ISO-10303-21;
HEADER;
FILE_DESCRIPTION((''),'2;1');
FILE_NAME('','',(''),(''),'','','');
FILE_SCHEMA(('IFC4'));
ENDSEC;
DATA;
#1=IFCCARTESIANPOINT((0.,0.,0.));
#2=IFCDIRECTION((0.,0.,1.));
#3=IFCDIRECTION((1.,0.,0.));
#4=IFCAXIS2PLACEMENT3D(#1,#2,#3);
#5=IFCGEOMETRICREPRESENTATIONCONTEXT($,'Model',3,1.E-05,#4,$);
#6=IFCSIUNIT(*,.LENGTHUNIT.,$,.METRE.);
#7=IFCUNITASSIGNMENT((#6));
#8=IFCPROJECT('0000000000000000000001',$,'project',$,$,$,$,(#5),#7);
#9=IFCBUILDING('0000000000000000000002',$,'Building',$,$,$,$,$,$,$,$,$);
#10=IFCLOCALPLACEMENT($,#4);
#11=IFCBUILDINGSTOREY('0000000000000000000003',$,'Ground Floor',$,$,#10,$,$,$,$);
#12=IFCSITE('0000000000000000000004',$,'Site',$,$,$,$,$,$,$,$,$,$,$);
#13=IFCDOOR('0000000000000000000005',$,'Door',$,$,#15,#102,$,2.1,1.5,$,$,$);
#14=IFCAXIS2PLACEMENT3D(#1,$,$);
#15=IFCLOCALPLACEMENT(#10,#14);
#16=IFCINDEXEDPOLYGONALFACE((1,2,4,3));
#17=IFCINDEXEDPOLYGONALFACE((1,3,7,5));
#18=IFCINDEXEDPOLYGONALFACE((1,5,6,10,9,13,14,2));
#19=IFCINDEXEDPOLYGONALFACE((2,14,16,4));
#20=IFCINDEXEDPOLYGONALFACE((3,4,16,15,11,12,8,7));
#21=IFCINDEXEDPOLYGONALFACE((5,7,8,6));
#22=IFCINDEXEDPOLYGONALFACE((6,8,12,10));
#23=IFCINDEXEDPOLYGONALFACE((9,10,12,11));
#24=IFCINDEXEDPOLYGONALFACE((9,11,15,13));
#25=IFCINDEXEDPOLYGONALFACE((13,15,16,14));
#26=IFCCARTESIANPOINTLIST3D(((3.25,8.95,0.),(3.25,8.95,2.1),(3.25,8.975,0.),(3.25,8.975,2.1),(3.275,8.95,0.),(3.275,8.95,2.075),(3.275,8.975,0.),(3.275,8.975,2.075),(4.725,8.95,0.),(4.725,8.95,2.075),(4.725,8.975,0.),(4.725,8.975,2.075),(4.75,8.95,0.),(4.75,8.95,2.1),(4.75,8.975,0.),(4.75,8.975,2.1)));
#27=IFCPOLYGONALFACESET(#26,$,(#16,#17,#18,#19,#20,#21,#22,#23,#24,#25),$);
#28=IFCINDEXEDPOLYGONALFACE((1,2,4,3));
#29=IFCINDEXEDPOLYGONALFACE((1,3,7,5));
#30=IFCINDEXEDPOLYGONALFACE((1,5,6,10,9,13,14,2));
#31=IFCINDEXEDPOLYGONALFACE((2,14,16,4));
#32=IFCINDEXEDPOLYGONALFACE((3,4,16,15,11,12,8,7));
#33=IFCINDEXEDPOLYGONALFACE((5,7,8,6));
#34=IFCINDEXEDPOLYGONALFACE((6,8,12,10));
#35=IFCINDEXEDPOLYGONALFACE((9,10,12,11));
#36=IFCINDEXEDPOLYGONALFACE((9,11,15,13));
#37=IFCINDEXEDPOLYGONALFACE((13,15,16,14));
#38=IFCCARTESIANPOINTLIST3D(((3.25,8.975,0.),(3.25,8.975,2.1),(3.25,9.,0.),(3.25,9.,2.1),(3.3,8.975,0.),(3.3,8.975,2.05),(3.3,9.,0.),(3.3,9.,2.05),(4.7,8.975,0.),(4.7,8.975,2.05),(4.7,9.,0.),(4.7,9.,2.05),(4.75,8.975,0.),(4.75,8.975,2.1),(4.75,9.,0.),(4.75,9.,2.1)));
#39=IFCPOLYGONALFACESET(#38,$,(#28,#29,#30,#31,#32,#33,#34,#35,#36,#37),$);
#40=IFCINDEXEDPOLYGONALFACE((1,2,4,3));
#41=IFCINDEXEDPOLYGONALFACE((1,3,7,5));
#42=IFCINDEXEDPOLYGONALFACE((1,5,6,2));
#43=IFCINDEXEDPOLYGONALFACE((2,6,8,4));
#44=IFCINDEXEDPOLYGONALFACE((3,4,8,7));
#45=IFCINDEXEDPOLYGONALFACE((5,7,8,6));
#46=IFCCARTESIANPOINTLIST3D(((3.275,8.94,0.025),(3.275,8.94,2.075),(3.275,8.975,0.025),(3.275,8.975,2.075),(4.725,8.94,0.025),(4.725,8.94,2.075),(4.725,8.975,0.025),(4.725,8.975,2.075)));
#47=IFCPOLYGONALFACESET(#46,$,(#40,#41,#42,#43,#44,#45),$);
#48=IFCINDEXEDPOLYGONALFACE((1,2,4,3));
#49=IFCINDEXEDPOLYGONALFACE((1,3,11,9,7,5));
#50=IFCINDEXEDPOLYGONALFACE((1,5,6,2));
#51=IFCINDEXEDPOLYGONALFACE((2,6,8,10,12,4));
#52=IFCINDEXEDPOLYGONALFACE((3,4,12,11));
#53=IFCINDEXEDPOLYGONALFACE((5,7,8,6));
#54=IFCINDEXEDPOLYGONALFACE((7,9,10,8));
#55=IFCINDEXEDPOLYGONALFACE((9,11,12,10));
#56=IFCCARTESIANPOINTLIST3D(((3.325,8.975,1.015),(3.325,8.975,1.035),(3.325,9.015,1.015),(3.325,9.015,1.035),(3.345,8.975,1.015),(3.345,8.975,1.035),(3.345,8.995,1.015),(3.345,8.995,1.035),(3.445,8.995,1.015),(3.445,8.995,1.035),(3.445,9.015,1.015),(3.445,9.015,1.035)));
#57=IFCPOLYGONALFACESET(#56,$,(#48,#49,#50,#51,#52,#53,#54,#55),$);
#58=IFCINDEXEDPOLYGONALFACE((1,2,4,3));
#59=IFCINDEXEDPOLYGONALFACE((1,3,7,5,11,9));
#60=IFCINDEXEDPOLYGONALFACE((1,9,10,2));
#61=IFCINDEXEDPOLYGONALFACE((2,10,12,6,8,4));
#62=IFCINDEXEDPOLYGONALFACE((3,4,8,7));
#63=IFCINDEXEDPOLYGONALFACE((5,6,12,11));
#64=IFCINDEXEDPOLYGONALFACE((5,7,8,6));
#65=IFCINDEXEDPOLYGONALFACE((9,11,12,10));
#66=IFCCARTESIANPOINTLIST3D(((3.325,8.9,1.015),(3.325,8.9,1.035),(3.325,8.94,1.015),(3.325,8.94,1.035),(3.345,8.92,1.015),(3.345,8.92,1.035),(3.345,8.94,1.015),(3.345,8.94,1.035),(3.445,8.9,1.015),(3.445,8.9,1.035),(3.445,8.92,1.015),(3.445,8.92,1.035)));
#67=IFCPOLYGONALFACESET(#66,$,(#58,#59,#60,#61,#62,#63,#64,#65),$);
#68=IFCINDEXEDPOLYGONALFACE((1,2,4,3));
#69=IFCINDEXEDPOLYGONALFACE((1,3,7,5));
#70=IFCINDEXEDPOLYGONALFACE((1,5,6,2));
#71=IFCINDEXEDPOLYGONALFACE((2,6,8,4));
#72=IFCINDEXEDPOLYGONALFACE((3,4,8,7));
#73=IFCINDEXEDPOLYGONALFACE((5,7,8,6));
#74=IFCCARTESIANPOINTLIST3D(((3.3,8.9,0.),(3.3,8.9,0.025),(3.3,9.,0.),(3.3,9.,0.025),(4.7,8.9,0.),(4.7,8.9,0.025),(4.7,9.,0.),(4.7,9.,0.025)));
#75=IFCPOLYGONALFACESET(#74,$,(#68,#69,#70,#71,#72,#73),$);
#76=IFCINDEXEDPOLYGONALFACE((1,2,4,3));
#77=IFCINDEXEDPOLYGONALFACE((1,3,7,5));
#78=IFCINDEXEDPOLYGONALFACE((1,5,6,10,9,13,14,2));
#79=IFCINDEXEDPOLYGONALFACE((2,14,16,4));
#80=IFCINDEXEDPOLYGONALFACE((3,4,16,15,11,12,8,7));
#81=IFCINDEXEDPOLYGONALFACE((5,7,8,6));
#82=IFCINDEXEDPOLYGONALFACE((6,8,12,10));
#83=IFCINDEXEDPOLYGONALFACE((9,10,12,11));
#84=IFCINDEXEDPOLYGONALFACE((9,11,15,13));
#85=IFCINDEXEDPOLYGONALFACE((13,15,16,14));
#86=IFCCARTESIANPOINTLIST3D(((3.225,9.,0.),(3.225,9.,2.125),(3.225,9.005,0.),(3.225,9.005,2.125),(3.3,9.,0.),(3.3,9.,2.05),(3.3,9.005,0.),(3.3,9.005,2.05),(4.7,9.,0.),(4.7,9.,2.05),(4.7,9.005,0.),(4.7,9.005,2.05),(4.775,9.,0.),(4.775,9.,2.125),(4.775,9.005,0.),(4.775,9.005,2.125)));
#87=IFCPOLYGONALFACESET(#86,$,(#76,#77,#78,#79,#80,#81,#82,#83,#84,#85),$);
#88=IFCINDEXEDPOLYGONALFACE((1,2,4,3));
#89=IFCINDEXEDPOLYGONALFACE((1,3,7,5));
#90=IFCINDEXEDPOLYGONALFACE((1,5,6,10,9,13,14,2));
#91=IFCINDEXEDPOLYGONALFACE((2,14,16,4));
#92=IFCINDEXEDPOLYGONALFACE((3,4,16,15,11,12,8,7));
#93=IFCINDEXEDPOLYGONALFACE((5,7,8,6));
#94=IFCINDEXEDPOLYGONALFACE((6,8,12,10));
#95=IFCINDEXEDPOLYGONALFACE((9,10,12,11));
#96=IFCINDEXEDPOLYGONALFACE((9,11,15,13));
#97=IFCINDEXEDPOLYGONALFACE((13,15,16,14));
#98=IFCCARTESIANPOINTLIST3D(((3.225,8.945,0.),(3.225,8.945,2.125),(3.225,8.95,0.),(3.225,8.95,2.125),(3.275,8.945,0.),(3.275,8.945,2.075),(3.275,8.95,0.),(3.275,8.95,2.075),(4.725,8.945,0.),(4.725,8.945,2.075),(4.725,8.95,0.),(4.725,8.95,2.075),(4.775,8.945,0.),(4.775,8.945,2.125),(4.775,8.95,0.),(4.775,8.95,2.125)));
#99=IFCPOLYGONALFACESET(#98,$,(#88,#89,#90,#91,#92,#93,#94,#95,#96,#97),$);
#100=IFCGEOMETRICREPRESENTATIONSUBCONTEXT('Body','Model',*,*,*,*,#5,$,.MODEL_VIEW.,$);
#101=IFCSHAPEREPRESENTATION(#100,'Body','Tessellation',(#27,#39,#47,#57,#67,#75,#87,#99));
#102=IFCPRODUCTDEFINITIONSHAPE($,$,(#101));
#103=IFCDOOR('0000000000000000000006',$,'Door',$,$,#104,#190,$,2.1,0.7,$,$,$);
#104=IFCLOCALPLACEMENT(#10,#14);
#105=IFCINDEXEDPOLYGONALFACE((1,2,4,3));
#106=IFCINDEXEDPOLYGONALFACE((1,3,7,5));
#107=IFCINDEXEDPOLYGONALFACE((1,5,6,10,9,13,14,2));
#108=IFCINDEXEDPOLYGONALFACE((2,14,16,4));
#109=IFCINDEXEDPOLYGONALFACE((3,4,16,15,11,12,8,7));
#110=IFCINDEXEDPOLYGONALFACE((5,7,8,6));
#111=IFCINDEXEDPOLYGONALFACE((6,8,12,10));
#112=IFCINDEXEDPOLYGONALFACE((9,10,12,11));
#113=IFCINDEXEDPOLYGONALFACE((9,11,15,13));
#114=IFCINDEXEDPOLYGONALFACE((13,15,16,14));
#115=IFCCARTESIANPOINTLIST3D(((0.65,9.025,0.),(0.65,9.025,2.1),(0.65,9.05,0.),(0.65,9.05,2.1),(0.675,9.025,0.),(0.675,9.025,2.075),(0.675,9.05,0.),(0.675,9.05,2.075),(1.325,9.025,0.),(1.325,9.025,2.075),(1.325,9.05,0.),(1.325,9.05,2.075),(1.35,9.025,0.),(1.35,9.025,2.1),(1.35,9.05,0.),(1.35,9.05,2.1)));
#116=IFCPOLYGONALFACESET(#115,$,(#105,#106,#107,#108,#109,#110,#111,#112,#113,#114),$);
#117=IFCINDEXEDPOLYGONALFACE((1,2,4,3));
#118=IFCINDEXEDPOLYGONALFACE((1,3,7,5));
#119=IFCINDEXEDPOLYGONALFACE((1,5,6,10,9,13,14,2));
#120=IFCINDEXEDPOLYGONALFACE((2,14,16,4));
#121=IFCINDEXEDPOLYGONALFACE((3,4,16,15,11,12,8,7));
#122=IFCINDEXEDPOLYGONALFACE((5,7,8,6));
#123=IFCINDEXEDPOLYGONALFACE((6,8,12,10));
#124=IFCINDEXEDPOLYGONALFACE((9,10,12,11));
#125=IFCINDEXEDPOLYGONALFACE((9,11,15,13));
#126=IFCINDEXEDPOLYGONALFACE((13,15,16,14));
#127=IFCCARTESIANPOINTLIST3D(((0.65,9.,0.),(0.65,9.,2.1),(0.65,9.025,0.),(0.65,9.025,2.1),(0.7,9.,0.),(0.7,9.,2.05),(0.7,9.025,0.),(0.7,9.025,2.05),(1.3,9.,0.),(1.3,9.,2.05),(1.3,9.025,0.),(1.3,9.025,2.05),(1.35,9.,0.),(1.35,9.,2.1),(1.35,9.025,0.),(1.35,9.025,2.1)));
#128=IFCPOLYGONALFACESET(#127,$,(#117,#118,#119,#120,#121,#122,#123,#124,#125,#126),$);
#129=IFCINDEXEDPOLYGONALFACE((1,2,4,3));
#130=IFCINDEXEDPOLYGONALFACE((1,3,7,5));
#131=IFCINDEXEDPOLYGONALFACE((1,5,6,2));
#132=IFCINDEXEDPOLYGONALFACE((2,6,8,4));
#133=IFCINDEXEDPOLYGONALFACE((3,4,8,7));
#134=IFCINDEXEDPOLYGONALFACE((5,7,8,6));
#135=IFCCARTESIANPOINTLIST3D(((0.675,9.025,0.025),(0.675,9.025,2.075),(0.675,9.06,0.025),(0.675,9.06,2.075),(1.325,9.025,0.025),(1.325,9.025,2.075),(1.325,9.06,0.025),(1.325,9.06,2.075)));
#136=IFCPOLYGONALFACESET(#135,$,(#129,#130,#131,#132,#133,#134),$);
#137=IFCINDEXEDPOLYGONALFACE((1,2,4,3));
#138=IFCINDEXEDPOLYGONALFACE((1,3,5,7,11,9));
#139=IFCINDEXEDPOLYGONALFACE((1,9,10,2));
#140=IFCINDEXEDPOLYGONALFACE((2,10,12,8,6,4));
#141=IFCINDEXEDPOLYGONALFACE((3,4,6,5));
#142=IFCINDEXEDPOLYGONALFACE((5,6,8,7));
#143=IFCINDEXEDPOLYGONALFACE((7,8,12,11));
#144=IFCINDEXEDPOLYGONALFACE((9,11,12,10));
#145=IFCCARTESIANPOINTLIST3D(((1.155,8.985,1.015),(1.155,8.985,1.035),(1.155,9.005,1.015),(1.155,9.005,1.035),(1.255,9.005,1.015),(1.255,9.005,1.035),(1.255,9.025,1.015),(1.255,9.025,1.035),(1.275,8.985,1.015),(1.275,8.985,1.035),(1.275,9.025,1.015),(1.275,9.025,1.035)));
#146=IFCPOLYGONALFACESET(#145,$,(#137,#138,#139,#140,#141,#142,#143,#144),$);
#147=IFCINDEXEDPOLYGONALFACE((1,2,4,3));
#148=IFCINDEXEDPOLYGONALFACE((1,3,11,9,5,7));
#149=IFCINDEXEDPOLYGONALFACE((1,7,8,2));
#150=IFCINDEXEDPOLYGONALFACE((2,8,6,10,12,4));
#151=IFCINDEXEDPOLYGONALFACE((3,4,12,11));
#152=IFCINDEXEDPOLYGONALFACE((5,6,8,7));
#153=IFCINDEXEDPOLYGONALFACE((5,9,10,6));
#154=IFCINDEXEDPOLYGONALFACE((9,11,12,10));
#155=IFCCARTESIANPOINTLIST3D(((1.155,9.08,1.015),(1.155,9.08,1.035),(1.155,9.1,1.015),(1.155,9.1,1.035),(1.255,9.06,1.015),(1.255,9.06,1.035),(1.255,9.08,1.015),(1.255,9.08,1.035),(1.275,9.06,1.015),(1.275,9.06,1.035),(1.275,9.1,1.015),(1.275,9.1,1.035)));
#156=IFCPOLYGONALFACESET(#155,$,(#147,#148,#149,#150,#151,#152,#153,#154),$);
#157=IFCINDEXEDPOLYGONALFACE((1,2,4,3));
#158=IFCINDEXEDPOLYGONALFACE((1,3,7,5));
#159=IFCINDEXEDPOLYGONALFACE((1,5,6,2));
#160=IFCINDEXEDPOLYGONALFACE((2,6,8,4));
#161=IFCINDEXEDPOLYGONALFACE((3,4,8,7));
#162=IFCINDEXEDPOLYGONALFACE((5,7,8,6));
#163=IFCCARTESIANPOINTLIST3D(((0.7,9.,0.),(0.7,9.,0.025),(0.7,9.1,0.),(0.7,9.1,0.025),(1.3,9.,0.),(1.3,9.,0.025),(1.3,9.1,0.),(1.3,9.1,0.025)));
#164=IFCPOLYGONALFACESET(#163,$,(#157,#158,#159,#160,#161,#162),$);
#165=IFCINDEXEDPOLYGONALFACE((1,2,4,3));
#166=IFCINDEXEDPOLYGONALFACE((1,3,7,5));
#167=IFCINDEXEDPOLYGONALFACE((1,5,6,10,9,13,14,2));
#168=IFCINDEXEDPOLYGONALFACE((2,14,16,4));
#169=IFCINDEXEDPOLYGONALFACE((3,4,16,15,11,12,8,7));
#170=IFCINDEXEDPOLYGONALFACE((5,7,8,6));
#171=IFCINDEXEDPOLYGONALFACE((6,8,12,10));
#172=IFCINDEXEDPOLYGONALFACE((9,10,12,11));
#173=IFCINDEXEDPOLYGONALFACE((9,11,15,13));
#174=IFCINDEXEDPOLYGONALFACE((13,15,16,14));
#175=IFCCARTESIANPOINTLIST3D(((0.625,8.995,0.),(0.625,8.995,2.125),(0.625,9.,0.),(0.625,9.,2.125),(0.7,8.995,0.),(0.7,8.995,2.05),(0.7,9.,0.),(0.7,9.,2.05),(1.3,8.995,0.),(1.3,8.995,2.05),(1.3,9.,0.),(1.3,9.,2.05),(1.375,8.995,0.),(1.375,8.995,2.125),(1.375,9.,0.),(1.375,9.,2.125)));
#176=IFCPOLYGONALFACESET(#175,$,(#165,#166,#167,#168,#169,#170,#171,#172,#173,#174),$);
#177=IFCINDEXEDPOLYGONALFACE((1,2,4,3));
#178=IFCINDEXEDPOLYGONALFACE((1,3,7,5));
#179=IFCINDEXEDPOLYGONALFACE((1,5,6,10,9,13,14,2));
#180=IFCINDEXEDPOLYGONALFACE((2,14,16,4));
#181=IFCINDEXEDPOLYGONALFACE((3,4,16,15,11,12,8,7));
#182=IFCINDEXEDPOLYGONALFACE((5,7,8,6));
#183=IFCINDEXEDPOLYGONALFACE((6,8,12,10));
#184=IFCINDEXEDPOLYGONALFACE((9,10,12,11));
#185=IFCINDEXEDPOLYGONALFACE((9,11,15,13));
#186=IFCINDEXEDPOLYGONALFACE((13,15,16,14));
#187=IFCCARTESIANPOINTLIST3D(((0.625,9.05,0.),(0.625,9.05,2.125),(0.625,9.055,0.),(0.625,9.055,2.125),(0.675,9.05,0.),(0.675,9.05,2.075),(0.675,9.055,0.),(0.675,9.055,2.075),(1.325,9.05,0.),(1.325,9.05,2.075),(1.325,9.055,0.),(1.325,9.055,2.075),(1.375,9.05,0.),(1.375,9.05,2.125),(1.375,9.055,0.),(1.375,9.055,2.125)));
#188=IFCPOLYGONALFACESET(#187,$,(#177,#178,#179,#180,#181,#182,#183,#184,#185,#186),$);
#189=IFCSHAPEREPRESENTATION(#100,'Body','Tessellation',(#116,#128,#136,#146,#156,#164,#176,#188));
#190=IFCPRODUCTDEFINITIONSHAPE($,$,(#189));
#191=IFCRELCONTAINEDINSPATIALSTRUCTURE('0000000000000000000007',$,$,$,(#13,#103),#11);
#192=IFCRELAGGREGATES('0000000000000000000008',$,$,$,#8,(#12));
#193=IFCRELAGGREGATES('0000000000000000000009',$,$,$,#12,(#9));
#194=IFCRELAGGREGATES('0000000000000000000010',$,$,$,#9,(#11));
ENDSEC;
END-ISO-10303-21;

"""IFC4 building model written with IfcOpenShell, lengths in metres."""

from ifc_helpers import new_model, si_unit, frame, origin_with_axes, place, context, subcontext, project, spatial, line, indexed_curve, outline, extrude, element, save


model = new_model("IFC4")

# Units and contexts
model_context = context("Model", 3, precision=1e-05, world=origin_with_axes())
body_context = subcontext(model_context, "Body", "Model", "MODEL_VIEW")
ifc_project = project(units=[si_unit("LENGTHUNIT", "METRE")], contexts=[model_context])

# Site, building, storey
site = spatial("IfcSite", under=ifc_project, Name="Site")
building = spatial("IfcBuilding", under=site, Name="Building")
storey_placement = place(None, origin_with_axes())
storey = spatial("IfcBuildingStorey", under=building, at=storey_placement, Name="Ground Floor")

# Doors
door_1_placement = place(storey_placement, frame((4.75, 9.0, 0.0), z_axis=(0.0, 0.0, 1.0), x_axis=(-1.0, 0.0, 0.0)))
element("IfcDoor", 1, at=door_1_placement, inside=storey, Name="Door", OverallHeight=2.1, OverallWidth=1.5, context=body_context, shape_type="SweptSolid", body=[
    extrude(outline(indexed_curve([(0.0, 0.0), (0.0, 2.1), (1.5, 2.1), (1.5, 0.0), (1.475, 0.0), (1.475, 2.075), (0.025, 2.075), (0.025, 0.0)], segments=[line(1, 2, 3, 4, 5, 6, 7, 8, 1)])), frame((0.0, 0.025, 0.0), z_axis=(0.0, -1.0, 0.0), x_axis=(1.0, 0.0, 0.0)), (0.0, 0.0, -1.0), 0.025),
    extrude(outline(indexed_curve([(0.0, 0.0), (0.0, 2.1), (1.5, 2.1), (1.5, 0.0), (1.45, 0.0), (1.45, 2.05), (0.05, 2.05), (0.05, 0.0)], segments=[line(1, 2, 3, 4, 5, 6, 7, 8, 1)])), frame((0.0, 0.0, 0.0), z_axis=(0.0, -1.0, 0.0), x_axis=(1.0, 0.0, 0.0)), (0.0, 0.0, -1.0), 0.025),
    extrude(outline(indexed_curve([(0.0, 0.0), (1.45, 0.0), (1.45, 0.035), (0.0, 0.035)], segments=[line(1, 2, 3, 4, 1)])), frame((0.025, 0.025, 0.025), z_axis=(0.0, 0.0, 1.0), x_axis=(1.0, 0.0, 0.0)), (0.0, 0.0, 1.0), 2.05),
    extrude(outline(indexed_curve([(0.0, 0.0), (0.0, -0.04), (-0.12, -0.04), (-0.12, -0.02), (-0.02, -0.02), (-0.02, 0.0)], segments=[line(1, 2, 3, 4, 5, 6, 1)])), frame((1.425, 0.025, 1.015), z_axis=(0.0, 0.0, 1.0), x_axis=(1.0, 0.0, 0.0)), (0.0, 0.0, 1.0), 0.02),
    extrude(outline(indexed_curve([(0.0, 0.0), (0.0, 0.04), (-0.12, 0.04), (-0.12, 0.02), (-0.02, 0.02), (-0.02, 0.0)], segments=[line(1, 2, 3, 4, 5, 6, 1)])), frame((1.425, 0.06, 1.015), z_axis=(0.0, 0.0, 1.0), x_axis=(1.0, 0.0, 0.0)), (0.0, 0.0, 1.0), 0.02),
    extrude(outline(indexed_curve([(0.0, 0.0), (1.4, 0.0), (1.4, 0.1), (0.0, 0.1)], segments=[line(1, 2, 3, 4, 1)])), frame((0.05, 0.0, 0.0), z_axis=(0.0, 0.0, 1.0), x_axis=(1.0, 0.0, 0.0)), (0.0, 0.0, 1.0), 0.025),
    extrude(outline(indexed_curve([(0.0, 0.0), (0.0, 2.125), (1.55, 2.125), (1.55, 0.0), (1.475, 0.0), (1.475, 2.05), (0.075, 2.05), (0.075, 0.0)], segments=[line(1, 2, 3, 4, 5, 6, 7, 8, 1)])), frame((-0.025, -0.005, 0.0), z_axis=(0.0, -1.0, 0.0), x_axis=(1.0, 0.0, 0.0)), (0.0, 0.0, -1.0), 0.005),
    extrude(outline(indexed_curve([(0.0, 0.0), (0.0, 2.125), (1.55, 2.125), (1.55, 0.0), (1.5, 0.0), (1.5, 2.075), (0.05, 2.075), (0.05, 0.0)], segments=[line(1, 2, 3, 4, 5, 6, 7, 8, 1)])), frame((-0.025, 0.05, 0.0), z_axis=(0.0, -1.0, 0.0), x_axis=(1.0, 0.0, 0.0)), (0.0, 0.0, -1.0), 0.005),
])
door_2_placement = place(storey_placement, frame((0.65, 9.0, 0.0), z_axis=(0.0, 0.0, 1.0), x_axis=(1.0, 0.0, 0.0)))
element("IfcDoor", 2, at=door_2_placement, inside=storey, Name="Door", OverallHeight=2.1, OverallWidth=0.7, context=body_context, shape_type="SweptSolid", body=[
    extrude(outline(indexed_curve([(0.0, 0.0), (0.0, 2.1), (0.7, 2.1), (0.7, 0.0), (0.675, 0.0), (0.675, 2.075), (0.025, 2.075), (0.025, 0.0)], segments=[line(1, 2, 3, 4, 5, 6, 7, 8, 1)])), frame((0.0, 0.025, 0.0), z_axis=(0.0, -1.0, 0.0), x_axis=(1.0, 0.0, 0.0)), (0.0, 0.0, -1.0), 0.025),
    extrude(outline(indexed_curve([(0.0, 0.0), (0.0, 2.1), (0.7, 2.1), (0.7, 0.0), (0.65, 0.0), (0.65, 2.05), (0.05, 2.05), (0.05, 0.0)], segments=[line(1, 2, 3, 4, 5, 6, 7, 8, 1)])), frame((0.0, 0.0, 0.0), z_axis=(0.0, -1.0, 0.0), x_axis=(1.0, 0.0, 0.0)), (0.0, 0.0, -1.0), 0.025),
    extrude(outline(indexed_curve([(0.0, 0.0), (0.65, 0.0), (0.65, 0.035), (0.0, 0.035)], segments=[line(1, 2, 3, 4, 1)])), frame((0.025, 0.025, 0.025), z_axis=(0.0, 0.0, 1.0), x_axis=(1.0, 0.0, 0.0)), (0.0, 0.0, 1.0), 2.05),
    extrude(outline(indexed_curve([(0.0, 0.0), (0.0, -0.04), (-0.12, -0.04), (-0.12, -0.02), (-0.02, -0.02), (-0.02, 0.0)], segments=[line(1, 2, 3, 4, 5, 6, 1)])), frame((0.625, 0.025, 1.015), z_axis=(0.0, 0.0, 1.0), x_axis=(1.0, 0.0, 0.0)), (0.0, 0.0, 1.0), 0.02),
    extrude(outline(indexed_curve([(0.0, 0.0), (0.0, 0.04), (-0.12, 0.04), (-0.12, 0.02), (-0.02, 0.02), (-0.02, 0.0)], segments=[line(1, 2, 3, 4, 5, 6, 1)])), frame((0.625, 0.06, 1.015), z_axis=(0.0, 0.0, 1.0), x_axis=(1.0, 0.0, 0.0)), (0.0, 0.0, 1.0), 0.02),
    extrude(outline(indexed_curve([(0.0, 0.0), (0.6, 0.0), (0.6, 0.1), (0.0, 0.1)], segments=[line(1, 2, 3, 4, 1)])), frame((0.05, 0.0, 0.0), z_axis=(0.0, 0.0, 1.0), x_axis=(1.0, 0.0, 0.0)), (0.0, 0.0, 1.0), 0.025),
    extrude(outline(indexed_curve([(0.0, 0.0), (0.0, 2.125), (0.75, 2.125), (0.75, 0.0), (0.675, 0.0), (0.675, 2.05), (0.075, 2.05), (0.075, 0.0)], segments=[line(1, 2, 3, 4, 5, 6, 7, 8, 1)])), frame((-0.025, -0.005, 0.0), z_axis=(0.0, -1.0, 0.0), x_axis=(1.0, 0.0, 0.0)), (0.0, 0.0, -1.0), 0.005),
    extrude(outline(indexed_curve([(0.0, 0.0), (0.0, 2.125), (0.75, 2.125), (0.75, 0.0), (0.7, 0.0), (0.7, 2.075), (0.05, 2.075), (0.05, 0.0)], segments=[line(1, 2, 3, 4, 5, 6, 7, 8, 1)])), frame((-0.025, 0.05, 0.0), z_axis=(0.0, -1.0, 0.0), x_axis=(1.0, 0.0, 0.0)), (0.0, 0.0, -1.0), 0.005),
])

save(model, "model.ifc")
